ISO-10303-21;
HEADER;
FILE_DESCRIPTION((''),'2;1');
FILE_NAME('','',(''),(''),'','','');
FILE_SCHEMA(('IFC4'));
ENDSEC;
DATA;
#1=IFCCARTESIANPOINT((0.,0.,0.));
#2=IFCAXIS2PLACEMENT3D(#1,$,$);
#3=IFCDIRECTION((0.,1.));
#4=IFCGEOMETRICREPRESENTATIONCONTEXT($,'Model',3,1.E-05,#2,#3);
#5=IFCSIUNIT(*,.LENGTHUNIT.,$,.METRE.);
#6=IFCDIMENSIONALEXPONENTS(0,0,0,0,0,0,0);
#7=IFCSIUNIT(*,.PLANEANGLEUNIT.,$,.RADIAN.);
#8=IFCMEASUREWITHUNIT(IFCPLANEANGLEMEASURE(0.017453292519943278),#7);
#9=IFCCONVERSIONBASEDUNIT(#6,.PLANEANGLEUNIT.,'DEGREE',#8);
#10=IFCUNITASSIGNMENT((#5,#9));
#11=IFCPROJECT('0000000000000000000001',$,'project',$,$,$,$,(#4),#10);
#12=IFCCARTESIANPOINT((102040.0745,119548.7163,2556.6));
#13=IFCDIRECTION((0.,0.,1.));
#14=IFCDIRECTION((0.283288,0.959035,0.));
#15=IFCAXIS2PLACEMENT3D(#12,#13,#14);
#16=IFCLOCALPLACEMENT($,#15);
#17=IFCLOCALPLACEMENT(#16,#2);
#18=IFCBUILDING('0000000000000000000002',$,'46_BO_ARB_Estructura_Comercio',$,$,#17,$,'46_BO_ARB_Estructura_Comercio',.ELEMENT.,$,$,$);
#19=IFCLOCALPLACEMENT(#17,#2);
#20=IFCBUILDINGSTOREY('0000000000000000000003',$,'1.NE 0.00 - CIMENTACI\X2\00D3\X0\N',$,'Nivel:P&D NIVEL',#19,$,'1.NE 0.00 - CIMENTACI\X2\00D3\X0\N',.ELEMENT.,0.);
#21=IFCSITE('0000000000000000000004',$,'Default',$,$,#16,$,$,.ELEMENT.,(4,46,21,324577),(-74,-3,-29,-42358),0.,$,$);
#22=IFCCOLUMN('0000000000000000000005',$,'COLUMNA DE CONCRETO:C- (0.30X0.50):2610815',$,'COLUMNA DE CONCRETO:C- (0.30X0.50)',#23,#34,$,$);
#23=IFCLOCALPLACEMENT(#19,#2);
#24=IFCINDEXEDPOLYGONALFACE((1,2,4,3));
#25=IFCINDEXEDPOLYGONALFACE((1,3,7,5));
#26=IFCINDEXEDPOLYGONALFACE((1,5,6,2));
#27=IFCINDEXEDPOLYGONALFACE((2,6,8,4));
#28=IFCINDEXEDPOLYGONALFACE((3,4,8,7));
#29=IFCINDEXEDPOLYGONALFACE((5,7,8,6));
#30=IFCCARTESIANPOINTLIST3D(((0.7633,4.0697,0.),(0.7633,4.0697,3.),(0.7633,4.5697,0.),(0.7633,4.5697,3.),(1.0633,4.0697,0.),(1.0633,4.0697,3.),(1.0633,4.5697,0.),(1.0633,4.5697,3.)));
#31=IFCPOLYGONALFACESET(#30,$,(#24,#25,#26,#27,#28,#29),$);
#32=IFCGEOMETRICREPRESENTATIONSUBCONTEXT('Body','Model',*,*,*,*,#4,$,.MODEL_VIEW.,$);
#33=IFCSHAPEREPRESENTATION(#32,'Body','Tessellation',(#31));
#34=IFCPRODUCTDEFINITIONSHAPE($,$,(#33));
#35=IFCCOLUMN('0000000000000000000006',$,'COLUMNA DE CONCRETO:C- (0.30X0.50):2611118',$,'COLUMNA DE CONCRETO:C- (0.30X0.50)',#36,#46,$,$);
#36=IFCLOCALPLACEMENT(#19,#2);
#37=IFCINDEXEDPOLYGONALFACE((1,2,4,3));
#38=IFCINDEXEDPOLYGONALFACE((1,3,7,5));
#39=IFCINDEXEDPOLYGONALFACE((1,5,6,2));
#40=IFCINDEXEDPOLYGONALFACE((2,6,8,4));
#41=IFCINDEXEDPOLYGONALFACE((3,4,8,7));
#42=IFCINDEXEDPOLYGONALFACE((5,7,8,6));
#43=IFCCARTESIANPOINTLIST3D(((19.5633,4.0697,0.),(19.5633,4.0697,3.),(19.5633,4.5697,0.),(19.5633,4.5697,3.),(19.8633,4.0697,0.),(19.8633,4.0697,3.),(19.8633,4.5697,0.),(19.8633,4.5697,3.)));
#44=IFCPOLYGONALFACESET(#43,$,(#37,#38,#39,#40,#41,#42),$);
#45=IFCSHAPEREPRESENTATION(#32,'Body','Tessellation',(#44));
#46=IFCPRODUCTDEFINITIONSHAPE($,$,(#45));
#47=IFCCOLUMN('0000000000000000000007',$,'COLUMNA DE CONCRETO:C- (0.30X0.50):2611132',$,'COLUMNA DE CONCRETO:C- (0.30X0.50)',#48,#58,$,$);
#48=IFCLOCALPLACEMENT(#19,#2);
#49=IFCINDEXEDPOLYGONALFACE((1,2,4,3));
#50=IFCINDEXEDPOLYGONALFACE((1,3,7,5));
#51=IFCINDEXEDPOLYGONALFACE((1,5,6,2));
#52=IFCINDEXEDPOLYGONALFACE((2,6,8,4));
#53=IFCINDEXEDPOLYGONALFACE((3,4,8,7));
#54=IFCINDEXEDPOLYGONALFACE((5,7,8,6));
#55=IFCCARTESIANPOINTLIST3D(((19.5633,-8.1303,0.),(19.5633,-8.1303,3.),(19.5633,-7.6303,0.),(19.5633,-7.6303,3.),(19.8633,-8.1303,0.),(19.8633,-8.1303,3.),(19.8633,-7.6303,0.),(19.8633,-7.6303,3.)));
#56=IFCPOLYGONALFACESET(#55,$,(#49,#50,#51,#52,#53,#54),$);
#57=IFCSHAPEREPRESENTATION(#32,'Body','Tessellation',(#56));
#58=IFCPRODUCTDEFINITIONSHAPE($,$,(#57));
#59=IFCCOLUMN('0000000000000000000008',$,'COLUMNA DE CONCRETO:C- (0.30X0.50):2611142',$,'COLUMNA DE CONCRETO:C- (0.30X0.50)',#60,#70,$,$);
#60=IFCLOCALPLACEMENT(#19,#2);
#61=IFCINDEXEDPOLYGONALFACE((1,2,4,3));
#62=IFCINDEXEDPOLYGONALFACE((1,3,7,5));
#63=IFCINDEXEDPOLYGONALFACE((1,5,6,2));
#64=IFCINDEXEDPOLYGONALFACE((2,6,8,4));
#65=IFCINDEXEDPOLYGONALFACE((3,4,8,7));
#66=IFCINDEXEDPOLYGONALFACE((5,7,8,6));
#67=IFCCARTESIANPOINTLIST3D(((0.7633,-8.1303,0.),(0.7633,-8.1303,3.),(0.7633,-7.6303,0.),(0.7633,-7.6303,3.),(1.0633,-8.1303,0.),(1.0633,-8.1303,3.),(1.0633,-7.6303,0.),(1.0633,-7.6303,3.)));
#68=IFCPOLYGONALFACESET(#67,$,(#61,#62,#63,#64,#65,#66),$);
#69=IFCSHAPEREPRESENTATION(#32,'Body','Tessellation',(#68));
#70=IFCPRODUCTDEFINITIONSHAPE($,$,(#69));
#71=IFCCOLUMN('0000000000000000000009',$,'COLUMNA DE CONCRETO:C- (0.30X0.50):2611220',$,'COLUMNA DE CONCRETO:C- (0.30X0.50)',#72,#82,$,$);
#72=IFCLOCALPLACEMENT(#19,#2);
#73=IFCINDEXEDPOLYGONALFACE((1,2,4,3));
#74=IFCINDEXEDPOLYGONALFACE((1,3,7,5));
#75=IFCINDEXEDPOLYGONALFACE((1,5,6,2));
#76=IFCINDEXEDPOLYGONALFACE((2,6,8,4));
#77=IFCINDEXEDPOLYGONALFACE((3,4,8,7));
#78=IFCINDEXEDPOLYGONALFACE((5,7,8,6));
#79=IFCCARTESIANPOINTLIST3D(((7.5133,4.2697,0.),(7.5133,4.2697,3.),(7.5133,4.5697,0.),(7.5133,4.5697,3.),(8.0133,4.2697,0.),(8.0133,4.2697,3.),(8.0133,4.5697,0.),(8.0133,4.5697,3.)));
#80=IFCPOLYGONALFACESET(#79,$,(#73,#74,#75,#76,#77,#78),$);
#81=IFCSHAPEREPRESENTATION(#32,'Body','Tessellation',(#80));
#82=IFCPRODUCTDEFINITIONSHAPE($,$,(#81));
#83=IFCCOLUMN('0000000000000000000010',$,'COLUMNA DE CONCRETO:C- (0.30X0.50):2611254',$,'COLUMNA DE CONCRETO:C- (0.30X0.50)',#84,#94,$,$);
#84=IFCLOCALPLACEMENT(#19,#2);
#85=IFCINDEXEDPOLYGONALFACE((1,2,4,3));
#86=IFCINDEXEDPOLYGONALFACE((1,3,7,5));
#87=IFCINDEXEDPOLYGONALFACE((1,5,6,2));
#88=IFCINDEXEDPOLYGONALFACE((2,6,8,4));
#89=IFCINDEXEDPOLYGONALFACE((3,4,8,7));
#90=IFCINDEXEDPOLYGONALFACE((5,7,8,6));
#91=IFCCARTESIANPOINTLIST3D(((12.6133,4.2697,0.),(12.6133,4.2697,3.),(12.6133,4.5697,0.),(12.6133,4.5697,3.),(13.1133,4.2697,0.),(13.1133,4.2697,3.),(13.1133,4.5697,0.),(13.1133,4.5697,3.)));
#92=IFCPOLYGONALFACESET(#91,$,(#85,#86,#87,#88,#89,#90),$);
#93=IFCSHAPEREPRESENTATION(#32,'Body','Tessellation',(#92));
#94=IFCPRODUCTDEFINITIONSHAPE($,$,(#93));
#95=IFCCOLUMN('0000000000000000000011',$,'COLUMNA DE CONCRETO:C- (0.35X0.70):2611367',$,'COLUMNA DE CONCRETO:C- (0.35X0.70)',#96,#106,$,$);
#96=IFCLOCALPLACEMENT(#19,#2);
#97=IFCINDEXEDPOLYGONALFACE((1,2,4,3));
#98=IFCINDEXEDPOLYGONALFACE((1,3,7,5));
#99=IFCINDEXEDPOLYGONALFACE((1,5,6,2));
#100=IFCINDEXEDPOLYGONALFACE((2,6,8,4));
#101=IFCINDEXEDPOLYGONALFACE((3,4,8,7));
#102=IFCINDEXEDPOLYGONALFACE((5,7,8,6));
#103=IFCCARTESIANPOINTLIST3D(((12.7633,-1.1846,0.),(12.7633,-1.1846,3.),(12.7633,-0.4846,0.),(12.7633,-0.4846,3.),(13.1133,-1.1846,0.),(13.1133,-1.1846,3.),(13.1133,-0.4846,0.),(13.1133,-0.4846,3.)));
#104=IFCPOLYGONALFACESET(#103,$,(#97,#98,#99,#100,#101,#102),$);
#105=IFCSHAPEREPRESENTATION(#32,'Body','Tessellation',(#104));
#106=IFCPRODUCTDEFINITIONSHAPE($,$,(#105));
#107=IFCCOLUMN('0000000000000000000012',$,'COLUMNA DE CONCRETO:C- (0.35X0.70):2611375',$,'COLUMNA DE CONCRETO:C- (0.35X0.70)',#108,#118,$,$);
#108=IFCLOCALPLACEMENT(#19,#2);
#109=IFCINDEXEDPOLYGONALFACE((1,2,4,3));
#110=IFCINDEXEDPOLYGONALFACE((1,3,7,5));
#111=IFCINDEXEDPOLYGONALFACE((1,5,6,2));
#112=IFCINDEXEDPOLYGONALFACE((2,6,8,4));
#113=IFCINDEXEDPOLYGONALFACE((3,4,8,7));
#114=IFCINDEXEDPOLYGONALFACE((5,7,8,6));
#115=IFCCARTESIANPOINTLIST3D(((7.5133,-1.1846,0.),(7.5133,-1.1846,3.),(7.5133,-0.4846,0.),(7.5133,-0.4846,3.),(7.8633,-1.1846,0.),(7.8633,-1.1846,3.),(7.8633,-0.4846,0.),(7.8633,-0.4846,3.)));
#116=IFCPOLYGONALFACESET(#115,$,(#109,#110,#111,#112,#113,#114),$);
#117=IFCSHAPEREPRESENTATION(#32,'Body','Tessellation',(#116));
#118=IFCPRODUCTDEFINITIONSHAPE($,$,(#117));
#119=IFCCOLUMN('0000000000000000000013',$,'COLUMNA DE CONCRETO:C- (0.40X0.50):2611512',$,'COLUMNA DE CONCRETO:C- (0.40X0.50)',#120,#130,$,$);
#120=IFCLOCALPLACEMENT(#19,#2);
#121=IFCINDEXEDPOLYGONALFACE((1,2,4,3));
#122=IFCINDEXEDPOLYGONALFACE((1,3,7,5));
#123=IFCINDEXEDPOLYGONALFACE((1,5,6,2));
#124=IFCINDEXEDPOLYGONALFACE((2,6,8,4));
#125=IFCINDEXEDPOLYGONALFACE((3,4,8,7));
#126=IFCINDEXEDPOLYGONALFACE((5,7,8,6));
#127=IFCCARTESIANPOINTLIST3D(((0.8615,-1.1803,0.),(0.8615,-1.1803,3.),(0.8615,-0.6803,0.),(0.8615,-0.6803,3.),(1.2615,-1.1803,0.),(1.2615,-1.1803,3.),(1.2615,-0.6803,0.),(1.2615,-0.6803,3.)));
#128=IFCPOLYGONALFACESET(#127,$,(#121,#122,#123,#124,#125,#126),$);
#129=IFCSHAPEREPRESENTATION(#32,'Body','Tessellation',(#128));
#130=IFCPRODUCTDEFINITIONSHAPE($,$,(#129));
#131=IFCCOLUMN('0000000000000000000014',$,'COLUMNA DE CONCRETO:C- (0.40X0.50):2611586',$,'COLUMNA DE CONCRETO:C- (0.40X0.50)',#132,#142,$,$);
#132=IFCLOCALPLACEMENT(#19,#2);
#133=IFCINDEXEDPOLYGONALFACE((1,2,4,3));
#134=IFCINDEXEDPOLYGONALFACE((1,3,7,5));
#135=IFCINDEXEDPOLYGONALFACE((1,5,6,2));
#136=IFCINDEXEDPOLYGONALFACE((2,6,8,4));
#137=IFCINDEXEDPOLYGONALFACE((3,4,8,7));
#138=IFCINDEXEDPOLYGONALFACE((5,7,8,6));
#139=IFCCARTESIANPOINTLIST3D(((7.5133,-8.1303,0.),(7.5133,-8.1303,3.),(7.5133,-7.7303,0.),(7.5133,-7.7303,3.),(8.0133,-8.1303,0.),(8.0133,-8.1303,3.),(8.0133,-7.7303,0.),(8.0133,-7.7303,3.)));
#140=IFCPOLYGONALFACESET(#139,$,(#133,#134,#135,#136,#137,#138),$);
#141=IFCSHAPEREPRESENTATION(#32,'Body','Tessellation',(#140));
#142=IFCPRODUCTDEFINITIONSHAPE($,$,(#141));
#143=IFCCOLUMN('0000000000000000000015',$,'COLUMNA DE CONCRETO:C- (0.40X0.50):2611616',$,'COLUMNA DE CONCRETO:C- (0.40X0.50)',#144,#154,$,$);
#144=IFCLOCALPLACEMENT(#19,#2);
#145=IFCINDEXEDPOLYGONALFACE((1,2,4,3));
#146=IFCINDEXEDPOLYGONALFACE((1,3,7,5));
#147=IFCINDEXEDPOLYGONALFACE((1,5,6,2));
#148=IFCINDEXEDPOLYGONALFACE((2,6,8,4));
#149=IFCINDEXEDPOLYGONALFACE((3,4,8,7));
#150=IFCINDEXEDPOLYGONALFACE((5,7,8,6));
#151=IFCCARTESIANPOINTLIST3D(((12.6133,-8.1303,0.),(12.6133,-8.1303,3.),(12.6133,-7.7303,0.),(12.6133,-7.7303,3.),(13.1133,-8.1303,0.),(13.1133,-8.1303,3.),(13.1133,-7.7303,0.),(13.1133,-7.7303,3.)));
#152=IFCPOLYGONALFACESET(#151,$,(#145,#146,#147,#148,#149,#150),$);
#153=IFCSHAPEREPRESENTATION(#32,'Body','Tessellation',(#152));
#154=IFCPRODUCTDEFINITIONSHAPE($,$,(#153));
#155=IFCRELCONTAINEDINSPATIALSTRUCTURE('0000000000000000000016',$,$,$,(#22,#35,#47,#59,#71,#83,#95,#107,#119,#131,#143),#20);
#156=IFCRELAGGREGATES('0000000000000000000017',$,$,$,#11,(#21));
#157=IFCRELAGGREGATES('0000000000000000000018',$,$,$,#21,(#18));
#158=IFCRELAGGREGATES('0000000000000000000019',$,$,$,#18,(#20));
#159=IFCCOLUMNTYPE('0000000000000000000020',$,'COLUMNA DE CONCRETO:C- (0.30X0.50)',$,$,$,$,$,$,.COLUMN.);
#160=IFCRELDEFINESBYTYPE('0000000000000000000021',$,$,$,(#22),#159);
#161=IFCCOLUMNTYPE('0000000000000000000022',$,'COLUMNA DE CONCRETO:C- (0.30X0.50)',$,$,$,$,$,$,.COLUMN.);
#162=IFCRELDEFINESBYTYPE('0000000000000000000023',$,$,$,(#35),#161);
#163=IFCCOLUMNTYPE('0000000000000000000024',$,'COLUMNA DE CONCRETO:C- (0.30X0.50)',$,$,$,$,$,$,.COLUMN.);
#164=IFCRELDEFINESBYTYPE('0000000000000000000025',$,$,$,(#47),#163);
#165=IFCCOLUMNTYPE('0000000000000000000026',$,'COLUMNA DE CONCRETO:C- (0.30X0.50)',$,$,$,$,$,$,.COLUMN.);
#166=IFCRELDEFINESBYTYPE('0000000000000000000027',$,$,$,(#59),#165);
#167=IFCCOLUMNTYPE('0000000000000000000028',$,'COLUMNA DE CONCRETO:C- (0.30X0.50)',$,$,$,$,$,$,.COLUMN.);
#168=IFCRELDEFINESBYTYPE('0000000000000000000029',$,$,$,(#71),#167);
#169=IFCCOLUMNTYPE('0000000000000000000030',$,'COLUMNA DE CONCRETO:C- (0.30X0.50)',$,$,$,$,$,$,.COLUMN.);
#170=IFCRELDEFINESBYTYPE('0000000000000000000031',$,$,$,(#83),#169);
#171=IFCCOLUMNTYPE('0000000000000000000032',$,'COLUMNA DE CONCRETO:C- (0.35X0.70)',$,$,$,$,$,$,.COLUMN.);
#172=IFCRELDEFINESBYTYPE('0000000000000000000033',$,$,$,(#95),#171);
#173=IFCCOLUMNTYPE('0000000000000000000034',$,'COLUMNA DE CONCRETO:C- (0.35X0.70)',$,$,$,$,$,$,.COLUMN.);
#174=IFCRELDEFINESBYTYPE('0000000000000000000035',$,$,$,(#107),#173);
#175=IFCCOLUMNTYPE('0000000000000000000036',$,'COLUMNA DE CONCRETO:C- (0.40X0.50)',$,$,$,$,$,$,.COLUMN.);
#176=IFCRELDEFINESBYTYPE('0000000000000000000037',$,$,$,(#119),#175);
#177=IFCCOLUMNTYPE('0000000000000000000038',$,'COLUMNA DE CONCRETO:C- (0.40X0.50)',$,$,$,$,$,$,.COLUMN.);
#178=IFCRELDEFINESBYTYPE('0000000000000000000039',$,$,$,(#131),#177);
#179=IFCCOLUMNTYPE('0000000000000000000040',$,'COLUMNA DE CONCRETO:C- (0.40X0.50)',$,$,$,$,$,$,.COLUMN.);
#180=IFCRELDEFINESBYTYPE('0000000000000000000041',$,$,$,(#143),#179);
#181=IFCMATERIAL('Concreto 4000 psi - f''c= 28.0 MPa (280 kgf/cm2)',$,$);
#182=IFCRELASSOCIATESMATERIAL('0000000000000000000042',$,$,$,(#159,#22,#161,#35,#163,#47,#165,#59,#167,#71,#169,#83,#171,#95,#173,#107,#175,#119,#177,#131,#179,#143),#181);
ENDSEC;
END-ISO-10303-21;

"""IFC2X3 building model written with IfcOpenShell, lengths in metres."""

from ifc_helpers import new_model, entity, si_unit, converted_unit, direction, frame, frame_2d, origin, origin_2d_with_axis, place, context, subcontext, project, spatial, rectangle, extrude, source, transform, mapped, material, type_object, type_shapes, element, save


model = new_model("IFC2X3")

# Units and contexts
model_context = context("Model", 3, precision=1e-05, world=origin(), true_north=direction((0.0, 1.0)))
body_context = subcontext(model_context, "Body", "Model", "MODEL_VIEW")
ifc_project = project(units=[si_unit("LENGTHUNIT", "METRE"), converted_unit("PLANEANGLEUNIT", "DEGREE", entity("IfcPlaneAngleMeasure", 0.017453292519943278), si_unit("PLANEANGLEUNIT", "RADIAN"), dimensions=[0, 0, 0, 0, 0, 0, 0])], contexts=[model_context])

# Site, building, storey
site_placement = place(None, frame((102040.0745, 119548.7163, 2556.6), z_axis=(0.0, 0.0, 1.0), x_axis=(0.283288, 0.959035, 0.0)))
site = spatial("IfcSite", under=ifc_project, at=site_placement, Name="Default", CompositionType="ELEMENT", RefLatitude=(4, 46, 21, 324577), RefLongitude=(-74, -3, -29, -42358), RefElevation=0.0)
building_placement = place(site_placement, origin())
building = spatial("IfcBuilding", under=site, at=building_placement, Name="46_BO_ARB_Estructura_Comercio", LongName="46_BO_ARB_Estructura_Comercio", CompositionType="ELEMENT")
storey_placement = place(building_placement, origin())
storey = spatial("IfcBuildingStorey", under=building, at=storey_placement, Name="1.NE 0.00 - CIMENTACIÓN", ObjectType="Nivel:P&D NIVEL", LongName="1.NE 0.00 - CIMENTACIÓN", CompositionType="ELEMENT", Elevation=0.0)

# Columns
ifc_material_1 = material(Name="Concreto 4000 psi - f'c= 28.0 MPa (280 kgf/cm2)")
column_type_1 = type_object("IfcColumnType", Name="COLUMNA DE CONCRETO:C- (0.30X0.50)", PredefinedType="COLUMN", material=ifc_material_1)
shared_shape_1 = source(origin(), body_context, "Body", "SweptSolid", [
    extrude(rectangle(XDim=0.3, YDim=0.5, at=frame_2d((0.0, 0.0), x_axis=(1.0, 0.0))), frame((0.9133, 4.3197, 0.0), z_axis=(0.0, 0.0, 1.0), x_axis=(-1.0, 0.0, 0.0)), (0.0, 0.0, 1.0), 3.0),
])
type_shapes(column_type_1, [shared_shape_1])
column_1_placement = place(storey_placement, origin())
element("IfcColumn", 1, at=column_1_placement, inside=storey, type_object=column_type_1, material=ifc_material_1, Name="COLUMNA DE CONCRETO:C- (0.30X0.50):2610815", ObjectType="COLUMNA DE CONCRETO:C- (0.30X0.50)", context=body_context, shape_type="MappedRepresentation", body=[
    mapped(shared_shape_1, transform((0.0, 0.0, 0.0), scale=1.0)),
])
column_type_2 = type_object("IfcColumnType", Name="COLUMNA DE CONCRETO:C- (0.30X0.50)", PredefinedType="COLUMN", material=ifc_material_1)
shared_shape_2 = source(origin(), body_context, "Body", "SweptSolid", [
    extrude(rectangle(XDim=0.3, YDim=0.5, at=origin_2d_with_axis()), frame((19.7133, 4.3197, 0.0), z_axis=(0.0, 0.0, 1.0), x_axis=(-1.0, 0.0, 0.0)), (0.0, 0.0, 1.0), 3.0),
])
type_shapes(column_type_2, [shared_shape_2])
column_2_placement = place(storey_placement, origin())
element("IfcColumn", 2, at=column_2_placement, inside=storey, type_object=column_type_2, material=ifc_material_1, Name="COLUMNA DE CONCRETO:C- (0.30X0.50):2611118", ObjectType="COLUMNA DE CONCRETO:C- (0.30X0.50)", context=body_context, shape_type="MappedRepresentation", body=[
    mapped(shared_shape_2, transform((0.0, 0.0, 0.0), scale=1.0)),
])
column_type_3 = type_object("IfcColumnType", Name="COLUMNA DE CONCRETO:C- (0.30X0.50)", PredefinedType="COLUMN", material=ifc_material_1)
shared_shape_3 = source(origin(), body_context, "Body", "SweptSolid", [
    extrude(rectangle(XDim=0.3, YDim=0.5, at=frame_2d((0.0, 0.0), x_axis=(1.0, 0.0))), frame((19.7133, -7.8803, 0.0), z_axis=(0.0, 0.0, 1.0), x_axis=(-1.0, 0.0, 0.0)), (0.0, 0.0, 1.0), 3.0),
])
type_shapes(column_type_3, [shared_shape_3])
column_3_placement = place(storey_placement, origin())
element("IfcColumn", 3, at=column_3_placement, inside=storey, type_object=column_type_3, material=ifc_material_1, Name="COLUMNA DE CONCRETO:C- (0.30X0.50):2611132", ObjectType="COLUMNA DE CONCRETO:C- (0.30X0.50)", context=body_context, shape_type="MappedRepresentation", body=[
    mapped(shared_shape_3, transform((0.0, 0.0, 0.0), scale=1.0)),
])
column_type_4 = type_object("IfcColumnType", Name="COLUMNA DE CONCRETO:C- (0.30X0.50)", PredefinedType="COLUMN", material=ifc_material_1)
shared_shape_4 = source(origin(), body_context, "Body", "SweptSolid", [
    extrude(rectangle(XDim=0.3, YDim=0.5, at=frame_2d((0.0, 0.0), x_axis=(1.0, 0.0))), frame((0.9133, -7.8803, 0.0), z_axis=(0.0, 0.0, 1.0), x_axis=(-1.0, 0.0, 0.0)), (0.0, 0.0, 1.0), 3.0),
])
type_shapes(column_type_4, [shared_shape_4])
column_4_placement = place(storey_placement, origin())
element("IfcColumn", 4, at=column_4_placement, inside=storey, type_object=column_type_4, material=ifc_material_1, Name="COLUMNA DE CONCRETO:C- (0.30X0.50):2611142", ObjectType="COLUMNA DE CONCRETO:C- (0.30X0.50)", context=body_context, shape_type="MappedRepresentation", body=[
    mapped(shared_shape_4, transform((0.0, 0.0, 0.0), scale=1.0)),
])
column_type_5 = type_object("IfcColumnType", Name="COLUMNA DE CONCRETO:C- (0.30X0.50)", PredefinedType="COLUMN", material=ifc_material_1)
shared_shape_5 = source(origin(), body_context, "Body", "SweptSolid", [
    extrude(rectangle(XDim=0.3, YDim=0.5, at=frame_2d((0.0, 0.0), x_axis=(1.0, 0.0))), frame((7.7633, 4.4197, 0.0), z_axis=(0.0, 0.0, 1.0), x_axis=(0.0, -1.0, 0.0)), (0.0, 0.0, 1.0), 3.0),
])
type_shapes(column_type_5, [shared_shape_5])
column_5_placement = place(storey_placement, origin())
element("IfcColumn", 5, at=column_5_placement, inside=storey, type_object=column_type_5, material=ifc_material_1, Name="COLUMNA DE CONCRETO:C- (0.30X0.50):2611220", ObjectType="COLUMNA DE CONCRETO:C- (0.30X0.50)", context=body_context, shape_type="MappedRepresentation", body=[
    mapped(shared_shape_5, transform((0.0, 0.0, 0.0), scale=1.0)),
])
column_type_6 = type_object("IfcColumnType", Name="COLUMNA DE CONCRETO:C- (0.30X0.50)", PredefinedType="COLUMN", material=ifc_material_1)
shared_shape_6 = source(origin(), body_context, "Body", "SweptSolid", [
    extrude(rectangle(XDim=0.3, YDim=0.5, at=frame_2d((0.0, 0.0), x_axis=(1.0, 0.0))), frame((12.8633, 4.4197, 0.0), z_axis=(0.0, 0.0, 1.0), x_axis=(0.0, -1.0, 0.0)), (0.0, 0.0, 1.0), 3.0),
])
type_shapes(column_type_6, [shared_shape_6])
column_6_placement = place(storey_placement, origin())
element("IfcColumn", 6, at=column_6_placement, inside=storey, type_object=column_type_6, material=ifc_material_1, Name="COLUMNA DE CONCRETO:C- (0.30X0.50):2611254", ObjectType="COLUMNA DE CONCRETO:C- (0.30X0.50)", context=body_context, shape_type="MappedRepresentation", body=[
    mapped(shared_shape_6, transform((0.0, 0.0, 0.0), scale=1.0)),
])
column_type_7 = type_object("IfcColumnType", Name="COLUMNA DE CONCRETO:C- (0.35X0.70)", PredefinedType="COLUMN", material=ifc_material_1)
shared_shape_7 = source(origin(), body_context, "Body", "SweptSolid", [
    extrude(rectangle(XDim=0.35, YDim=0.7, at=frame_2d((0.0, 0.0), x_axis=(1.0, 0.0))), frame((12.9383, -0.8346, 0.0)), (0.0, 0.0, 1.0), 3.0),
])
type_shapes(column_type_7, [shared_shape_7])
column_7_placement = place(storey_placement, origin())
element("IfcColumn", 7, at=column_7_placement, inside=storey, type_object=column_type_7, material=ifc_material_1, Name="COLUMNA DE CONCRETO:C- (0.35X0.70):2611367", ObjectType="COLUMNA DE CONCRETO:C- (0.35X0.70)", context=body_context, shape_type="MappedRepresentation", body=[
    mapped(shared_shape_7, transform((0.0, 0.0, 0.0), scale=1.0)),
])
column_type_8 = type_object("IfcColumnType", Name="COLUMNA DE CONCRETO:C- (0.35X0.70)", PredefinedType="COLUMN", material=ifc_material_1)
shared_shape_8 = source(origin(), body_context, "Body", "SweptSolid", [
    extrude(rectangle(XDim=0.7, YDim=0.35, at=frame_2d((0.0, 0.0), x_axis=(1.0, 0.0))), frame((7.6883, -0.8346, 0.0), z_axis=(0.0, 0.0, 1.0), x_axis=(0.0, 1.0, 0.0)), (0.0, 0.0, 1.0), 3.0),
])
type_shapes(column_type_8, [shared_shape_8])
column_8_placement = place(storey_placement, origin())
element("IfcColumn", 8, at=column_8_placement, inside=storey, type_object=column_type_8, material=ifc_material_1, Name="COLUMNA DE CONCRETO:C- (0.35X0.70):2611375", ObjectType="COLUMNA DE CONCRETO:C- (0.35X0.70)", context=body_context, shape_type="MappedRepresentation", body=[
    mapped(shared_shape_8, transform((0.0, 0.0, 0.0), scale=1.0)),
])
column_type_9 = type_object("IfcColumnType", Name="COLUMNA DE CONCRETO:C- (0.40X0.50)", PredefinedType="COLUMN", material=ifc_material_1)
shared_shape_9 = source(origin(), body_context, "Body", "SweptSolid", [
    extrude(rectangle(XDim=0.4, YDim=0.5, at=origin_2d_with_axis()), frame((1.0615, -0.9303, 0.0), z_axis=(0.0, 0.0, 1.0), x_axis=(-1.0, 0.0, 0.0)), (0.0, 0.0, 1.0), 3.0),
])
type_shapes(column_type_9, [shared_shape_9])
column_9_placement = place(storey_placement, origin())
element("IfcColumn", 9, at=column_9_placement, inside=storey, type_object=column_type_9, material=ifc_material_1, Name="COLUMNA DE CONCRETO:C- (0.40X0.50):2611512", ObjectType="COLUMNA DE CONCRETO:C- (0.40X0.50)", context=body_context, shape_type="MappedRepresentation", body=[
    mapped(shared_shape_9, transform((0.0, 0.0, 0.0), scale=1.0)),
])
column_type_10 = type_object("IfcColumnType", Name="COLUMNA DE CONCRETO:C- (0.40X0.50)", PredefinedType="COLUMN", material=ifc_material_1)
shared_shape_10 = source(origin(), body_context, "Body", "SweptSolid", [
    extrude(rectangle(XDim=0.4, YDim=0.5, at=frame_2d((0.0, 0.0), x_axis=(1.0, 0.0))), frame((7.7633, -7.9303, 0.0), z_axis=(0.0, 0.0, 1.0), x_axis=(0.0, -1.0, 0.0)), (0.0, 0.0, 1.0), 3.0),
])
type_shapes(column_type_10, [shared_shape_10])
column_10_placement = place(storey_placement, origin())
element("IfcColumn", 10, at=column_10_placement, inside=storey, type_object=column_type_10, material=ifc_material_1, Name="COLUMNA DE CONCRETO:C- (0.40X0.50):2611586", ObjectType="COLUMNA DE CONCRETO:C- (0.40X0.50)", context=body_context, shape_type="MappedRepresentation", body=[
    mapped(shared_shape_10, transform((0.0, 0.0, 0.0), scale=1.0)),
])
column_type_11 = type_object("IfcColumnType", Name="COLUMNA DE CONCRETO:C- (0.40X0.50)", PredefinedType="COLUMN", material=ifc_material_1)
shared_shape_11 = source(origin(), body_context, "Body", "SweptSolid", [
    extrude(rectangle(XDim=0.4, YDim=0.5, at=frame_2d((0.0, 0.0), x_axis=(1.0, 0.0))), frame((12.8633, -7.9303, 0.0), z_axis=(0.0, 0.0, 1.0), x_axis=(0.0, -1.0, 0.0)), (0.0, 0.0, 1.0), 3.0),
])
type_shapes(column_type_11, [shared_shape_11])
column_11_placement = place(storey_placement, origin())
element("IfcColumn", 11, at=column_11_placement, inside=storey, type_object=column_type_11, material=ifc_material_1, Name="COLUMNA DE CONCRETO:C- (0.40X0.50):2611616", ObjectType="COLUMNA DE CONCRETO:C- (0.40X0.50)", context=body_context, shape_type="MappedRepresentation", body=[
    mapped(shared_shape_11, transform((0.0, 0.0, 0.0), scale=1.0)),
])

save(model, "model.ifc")
